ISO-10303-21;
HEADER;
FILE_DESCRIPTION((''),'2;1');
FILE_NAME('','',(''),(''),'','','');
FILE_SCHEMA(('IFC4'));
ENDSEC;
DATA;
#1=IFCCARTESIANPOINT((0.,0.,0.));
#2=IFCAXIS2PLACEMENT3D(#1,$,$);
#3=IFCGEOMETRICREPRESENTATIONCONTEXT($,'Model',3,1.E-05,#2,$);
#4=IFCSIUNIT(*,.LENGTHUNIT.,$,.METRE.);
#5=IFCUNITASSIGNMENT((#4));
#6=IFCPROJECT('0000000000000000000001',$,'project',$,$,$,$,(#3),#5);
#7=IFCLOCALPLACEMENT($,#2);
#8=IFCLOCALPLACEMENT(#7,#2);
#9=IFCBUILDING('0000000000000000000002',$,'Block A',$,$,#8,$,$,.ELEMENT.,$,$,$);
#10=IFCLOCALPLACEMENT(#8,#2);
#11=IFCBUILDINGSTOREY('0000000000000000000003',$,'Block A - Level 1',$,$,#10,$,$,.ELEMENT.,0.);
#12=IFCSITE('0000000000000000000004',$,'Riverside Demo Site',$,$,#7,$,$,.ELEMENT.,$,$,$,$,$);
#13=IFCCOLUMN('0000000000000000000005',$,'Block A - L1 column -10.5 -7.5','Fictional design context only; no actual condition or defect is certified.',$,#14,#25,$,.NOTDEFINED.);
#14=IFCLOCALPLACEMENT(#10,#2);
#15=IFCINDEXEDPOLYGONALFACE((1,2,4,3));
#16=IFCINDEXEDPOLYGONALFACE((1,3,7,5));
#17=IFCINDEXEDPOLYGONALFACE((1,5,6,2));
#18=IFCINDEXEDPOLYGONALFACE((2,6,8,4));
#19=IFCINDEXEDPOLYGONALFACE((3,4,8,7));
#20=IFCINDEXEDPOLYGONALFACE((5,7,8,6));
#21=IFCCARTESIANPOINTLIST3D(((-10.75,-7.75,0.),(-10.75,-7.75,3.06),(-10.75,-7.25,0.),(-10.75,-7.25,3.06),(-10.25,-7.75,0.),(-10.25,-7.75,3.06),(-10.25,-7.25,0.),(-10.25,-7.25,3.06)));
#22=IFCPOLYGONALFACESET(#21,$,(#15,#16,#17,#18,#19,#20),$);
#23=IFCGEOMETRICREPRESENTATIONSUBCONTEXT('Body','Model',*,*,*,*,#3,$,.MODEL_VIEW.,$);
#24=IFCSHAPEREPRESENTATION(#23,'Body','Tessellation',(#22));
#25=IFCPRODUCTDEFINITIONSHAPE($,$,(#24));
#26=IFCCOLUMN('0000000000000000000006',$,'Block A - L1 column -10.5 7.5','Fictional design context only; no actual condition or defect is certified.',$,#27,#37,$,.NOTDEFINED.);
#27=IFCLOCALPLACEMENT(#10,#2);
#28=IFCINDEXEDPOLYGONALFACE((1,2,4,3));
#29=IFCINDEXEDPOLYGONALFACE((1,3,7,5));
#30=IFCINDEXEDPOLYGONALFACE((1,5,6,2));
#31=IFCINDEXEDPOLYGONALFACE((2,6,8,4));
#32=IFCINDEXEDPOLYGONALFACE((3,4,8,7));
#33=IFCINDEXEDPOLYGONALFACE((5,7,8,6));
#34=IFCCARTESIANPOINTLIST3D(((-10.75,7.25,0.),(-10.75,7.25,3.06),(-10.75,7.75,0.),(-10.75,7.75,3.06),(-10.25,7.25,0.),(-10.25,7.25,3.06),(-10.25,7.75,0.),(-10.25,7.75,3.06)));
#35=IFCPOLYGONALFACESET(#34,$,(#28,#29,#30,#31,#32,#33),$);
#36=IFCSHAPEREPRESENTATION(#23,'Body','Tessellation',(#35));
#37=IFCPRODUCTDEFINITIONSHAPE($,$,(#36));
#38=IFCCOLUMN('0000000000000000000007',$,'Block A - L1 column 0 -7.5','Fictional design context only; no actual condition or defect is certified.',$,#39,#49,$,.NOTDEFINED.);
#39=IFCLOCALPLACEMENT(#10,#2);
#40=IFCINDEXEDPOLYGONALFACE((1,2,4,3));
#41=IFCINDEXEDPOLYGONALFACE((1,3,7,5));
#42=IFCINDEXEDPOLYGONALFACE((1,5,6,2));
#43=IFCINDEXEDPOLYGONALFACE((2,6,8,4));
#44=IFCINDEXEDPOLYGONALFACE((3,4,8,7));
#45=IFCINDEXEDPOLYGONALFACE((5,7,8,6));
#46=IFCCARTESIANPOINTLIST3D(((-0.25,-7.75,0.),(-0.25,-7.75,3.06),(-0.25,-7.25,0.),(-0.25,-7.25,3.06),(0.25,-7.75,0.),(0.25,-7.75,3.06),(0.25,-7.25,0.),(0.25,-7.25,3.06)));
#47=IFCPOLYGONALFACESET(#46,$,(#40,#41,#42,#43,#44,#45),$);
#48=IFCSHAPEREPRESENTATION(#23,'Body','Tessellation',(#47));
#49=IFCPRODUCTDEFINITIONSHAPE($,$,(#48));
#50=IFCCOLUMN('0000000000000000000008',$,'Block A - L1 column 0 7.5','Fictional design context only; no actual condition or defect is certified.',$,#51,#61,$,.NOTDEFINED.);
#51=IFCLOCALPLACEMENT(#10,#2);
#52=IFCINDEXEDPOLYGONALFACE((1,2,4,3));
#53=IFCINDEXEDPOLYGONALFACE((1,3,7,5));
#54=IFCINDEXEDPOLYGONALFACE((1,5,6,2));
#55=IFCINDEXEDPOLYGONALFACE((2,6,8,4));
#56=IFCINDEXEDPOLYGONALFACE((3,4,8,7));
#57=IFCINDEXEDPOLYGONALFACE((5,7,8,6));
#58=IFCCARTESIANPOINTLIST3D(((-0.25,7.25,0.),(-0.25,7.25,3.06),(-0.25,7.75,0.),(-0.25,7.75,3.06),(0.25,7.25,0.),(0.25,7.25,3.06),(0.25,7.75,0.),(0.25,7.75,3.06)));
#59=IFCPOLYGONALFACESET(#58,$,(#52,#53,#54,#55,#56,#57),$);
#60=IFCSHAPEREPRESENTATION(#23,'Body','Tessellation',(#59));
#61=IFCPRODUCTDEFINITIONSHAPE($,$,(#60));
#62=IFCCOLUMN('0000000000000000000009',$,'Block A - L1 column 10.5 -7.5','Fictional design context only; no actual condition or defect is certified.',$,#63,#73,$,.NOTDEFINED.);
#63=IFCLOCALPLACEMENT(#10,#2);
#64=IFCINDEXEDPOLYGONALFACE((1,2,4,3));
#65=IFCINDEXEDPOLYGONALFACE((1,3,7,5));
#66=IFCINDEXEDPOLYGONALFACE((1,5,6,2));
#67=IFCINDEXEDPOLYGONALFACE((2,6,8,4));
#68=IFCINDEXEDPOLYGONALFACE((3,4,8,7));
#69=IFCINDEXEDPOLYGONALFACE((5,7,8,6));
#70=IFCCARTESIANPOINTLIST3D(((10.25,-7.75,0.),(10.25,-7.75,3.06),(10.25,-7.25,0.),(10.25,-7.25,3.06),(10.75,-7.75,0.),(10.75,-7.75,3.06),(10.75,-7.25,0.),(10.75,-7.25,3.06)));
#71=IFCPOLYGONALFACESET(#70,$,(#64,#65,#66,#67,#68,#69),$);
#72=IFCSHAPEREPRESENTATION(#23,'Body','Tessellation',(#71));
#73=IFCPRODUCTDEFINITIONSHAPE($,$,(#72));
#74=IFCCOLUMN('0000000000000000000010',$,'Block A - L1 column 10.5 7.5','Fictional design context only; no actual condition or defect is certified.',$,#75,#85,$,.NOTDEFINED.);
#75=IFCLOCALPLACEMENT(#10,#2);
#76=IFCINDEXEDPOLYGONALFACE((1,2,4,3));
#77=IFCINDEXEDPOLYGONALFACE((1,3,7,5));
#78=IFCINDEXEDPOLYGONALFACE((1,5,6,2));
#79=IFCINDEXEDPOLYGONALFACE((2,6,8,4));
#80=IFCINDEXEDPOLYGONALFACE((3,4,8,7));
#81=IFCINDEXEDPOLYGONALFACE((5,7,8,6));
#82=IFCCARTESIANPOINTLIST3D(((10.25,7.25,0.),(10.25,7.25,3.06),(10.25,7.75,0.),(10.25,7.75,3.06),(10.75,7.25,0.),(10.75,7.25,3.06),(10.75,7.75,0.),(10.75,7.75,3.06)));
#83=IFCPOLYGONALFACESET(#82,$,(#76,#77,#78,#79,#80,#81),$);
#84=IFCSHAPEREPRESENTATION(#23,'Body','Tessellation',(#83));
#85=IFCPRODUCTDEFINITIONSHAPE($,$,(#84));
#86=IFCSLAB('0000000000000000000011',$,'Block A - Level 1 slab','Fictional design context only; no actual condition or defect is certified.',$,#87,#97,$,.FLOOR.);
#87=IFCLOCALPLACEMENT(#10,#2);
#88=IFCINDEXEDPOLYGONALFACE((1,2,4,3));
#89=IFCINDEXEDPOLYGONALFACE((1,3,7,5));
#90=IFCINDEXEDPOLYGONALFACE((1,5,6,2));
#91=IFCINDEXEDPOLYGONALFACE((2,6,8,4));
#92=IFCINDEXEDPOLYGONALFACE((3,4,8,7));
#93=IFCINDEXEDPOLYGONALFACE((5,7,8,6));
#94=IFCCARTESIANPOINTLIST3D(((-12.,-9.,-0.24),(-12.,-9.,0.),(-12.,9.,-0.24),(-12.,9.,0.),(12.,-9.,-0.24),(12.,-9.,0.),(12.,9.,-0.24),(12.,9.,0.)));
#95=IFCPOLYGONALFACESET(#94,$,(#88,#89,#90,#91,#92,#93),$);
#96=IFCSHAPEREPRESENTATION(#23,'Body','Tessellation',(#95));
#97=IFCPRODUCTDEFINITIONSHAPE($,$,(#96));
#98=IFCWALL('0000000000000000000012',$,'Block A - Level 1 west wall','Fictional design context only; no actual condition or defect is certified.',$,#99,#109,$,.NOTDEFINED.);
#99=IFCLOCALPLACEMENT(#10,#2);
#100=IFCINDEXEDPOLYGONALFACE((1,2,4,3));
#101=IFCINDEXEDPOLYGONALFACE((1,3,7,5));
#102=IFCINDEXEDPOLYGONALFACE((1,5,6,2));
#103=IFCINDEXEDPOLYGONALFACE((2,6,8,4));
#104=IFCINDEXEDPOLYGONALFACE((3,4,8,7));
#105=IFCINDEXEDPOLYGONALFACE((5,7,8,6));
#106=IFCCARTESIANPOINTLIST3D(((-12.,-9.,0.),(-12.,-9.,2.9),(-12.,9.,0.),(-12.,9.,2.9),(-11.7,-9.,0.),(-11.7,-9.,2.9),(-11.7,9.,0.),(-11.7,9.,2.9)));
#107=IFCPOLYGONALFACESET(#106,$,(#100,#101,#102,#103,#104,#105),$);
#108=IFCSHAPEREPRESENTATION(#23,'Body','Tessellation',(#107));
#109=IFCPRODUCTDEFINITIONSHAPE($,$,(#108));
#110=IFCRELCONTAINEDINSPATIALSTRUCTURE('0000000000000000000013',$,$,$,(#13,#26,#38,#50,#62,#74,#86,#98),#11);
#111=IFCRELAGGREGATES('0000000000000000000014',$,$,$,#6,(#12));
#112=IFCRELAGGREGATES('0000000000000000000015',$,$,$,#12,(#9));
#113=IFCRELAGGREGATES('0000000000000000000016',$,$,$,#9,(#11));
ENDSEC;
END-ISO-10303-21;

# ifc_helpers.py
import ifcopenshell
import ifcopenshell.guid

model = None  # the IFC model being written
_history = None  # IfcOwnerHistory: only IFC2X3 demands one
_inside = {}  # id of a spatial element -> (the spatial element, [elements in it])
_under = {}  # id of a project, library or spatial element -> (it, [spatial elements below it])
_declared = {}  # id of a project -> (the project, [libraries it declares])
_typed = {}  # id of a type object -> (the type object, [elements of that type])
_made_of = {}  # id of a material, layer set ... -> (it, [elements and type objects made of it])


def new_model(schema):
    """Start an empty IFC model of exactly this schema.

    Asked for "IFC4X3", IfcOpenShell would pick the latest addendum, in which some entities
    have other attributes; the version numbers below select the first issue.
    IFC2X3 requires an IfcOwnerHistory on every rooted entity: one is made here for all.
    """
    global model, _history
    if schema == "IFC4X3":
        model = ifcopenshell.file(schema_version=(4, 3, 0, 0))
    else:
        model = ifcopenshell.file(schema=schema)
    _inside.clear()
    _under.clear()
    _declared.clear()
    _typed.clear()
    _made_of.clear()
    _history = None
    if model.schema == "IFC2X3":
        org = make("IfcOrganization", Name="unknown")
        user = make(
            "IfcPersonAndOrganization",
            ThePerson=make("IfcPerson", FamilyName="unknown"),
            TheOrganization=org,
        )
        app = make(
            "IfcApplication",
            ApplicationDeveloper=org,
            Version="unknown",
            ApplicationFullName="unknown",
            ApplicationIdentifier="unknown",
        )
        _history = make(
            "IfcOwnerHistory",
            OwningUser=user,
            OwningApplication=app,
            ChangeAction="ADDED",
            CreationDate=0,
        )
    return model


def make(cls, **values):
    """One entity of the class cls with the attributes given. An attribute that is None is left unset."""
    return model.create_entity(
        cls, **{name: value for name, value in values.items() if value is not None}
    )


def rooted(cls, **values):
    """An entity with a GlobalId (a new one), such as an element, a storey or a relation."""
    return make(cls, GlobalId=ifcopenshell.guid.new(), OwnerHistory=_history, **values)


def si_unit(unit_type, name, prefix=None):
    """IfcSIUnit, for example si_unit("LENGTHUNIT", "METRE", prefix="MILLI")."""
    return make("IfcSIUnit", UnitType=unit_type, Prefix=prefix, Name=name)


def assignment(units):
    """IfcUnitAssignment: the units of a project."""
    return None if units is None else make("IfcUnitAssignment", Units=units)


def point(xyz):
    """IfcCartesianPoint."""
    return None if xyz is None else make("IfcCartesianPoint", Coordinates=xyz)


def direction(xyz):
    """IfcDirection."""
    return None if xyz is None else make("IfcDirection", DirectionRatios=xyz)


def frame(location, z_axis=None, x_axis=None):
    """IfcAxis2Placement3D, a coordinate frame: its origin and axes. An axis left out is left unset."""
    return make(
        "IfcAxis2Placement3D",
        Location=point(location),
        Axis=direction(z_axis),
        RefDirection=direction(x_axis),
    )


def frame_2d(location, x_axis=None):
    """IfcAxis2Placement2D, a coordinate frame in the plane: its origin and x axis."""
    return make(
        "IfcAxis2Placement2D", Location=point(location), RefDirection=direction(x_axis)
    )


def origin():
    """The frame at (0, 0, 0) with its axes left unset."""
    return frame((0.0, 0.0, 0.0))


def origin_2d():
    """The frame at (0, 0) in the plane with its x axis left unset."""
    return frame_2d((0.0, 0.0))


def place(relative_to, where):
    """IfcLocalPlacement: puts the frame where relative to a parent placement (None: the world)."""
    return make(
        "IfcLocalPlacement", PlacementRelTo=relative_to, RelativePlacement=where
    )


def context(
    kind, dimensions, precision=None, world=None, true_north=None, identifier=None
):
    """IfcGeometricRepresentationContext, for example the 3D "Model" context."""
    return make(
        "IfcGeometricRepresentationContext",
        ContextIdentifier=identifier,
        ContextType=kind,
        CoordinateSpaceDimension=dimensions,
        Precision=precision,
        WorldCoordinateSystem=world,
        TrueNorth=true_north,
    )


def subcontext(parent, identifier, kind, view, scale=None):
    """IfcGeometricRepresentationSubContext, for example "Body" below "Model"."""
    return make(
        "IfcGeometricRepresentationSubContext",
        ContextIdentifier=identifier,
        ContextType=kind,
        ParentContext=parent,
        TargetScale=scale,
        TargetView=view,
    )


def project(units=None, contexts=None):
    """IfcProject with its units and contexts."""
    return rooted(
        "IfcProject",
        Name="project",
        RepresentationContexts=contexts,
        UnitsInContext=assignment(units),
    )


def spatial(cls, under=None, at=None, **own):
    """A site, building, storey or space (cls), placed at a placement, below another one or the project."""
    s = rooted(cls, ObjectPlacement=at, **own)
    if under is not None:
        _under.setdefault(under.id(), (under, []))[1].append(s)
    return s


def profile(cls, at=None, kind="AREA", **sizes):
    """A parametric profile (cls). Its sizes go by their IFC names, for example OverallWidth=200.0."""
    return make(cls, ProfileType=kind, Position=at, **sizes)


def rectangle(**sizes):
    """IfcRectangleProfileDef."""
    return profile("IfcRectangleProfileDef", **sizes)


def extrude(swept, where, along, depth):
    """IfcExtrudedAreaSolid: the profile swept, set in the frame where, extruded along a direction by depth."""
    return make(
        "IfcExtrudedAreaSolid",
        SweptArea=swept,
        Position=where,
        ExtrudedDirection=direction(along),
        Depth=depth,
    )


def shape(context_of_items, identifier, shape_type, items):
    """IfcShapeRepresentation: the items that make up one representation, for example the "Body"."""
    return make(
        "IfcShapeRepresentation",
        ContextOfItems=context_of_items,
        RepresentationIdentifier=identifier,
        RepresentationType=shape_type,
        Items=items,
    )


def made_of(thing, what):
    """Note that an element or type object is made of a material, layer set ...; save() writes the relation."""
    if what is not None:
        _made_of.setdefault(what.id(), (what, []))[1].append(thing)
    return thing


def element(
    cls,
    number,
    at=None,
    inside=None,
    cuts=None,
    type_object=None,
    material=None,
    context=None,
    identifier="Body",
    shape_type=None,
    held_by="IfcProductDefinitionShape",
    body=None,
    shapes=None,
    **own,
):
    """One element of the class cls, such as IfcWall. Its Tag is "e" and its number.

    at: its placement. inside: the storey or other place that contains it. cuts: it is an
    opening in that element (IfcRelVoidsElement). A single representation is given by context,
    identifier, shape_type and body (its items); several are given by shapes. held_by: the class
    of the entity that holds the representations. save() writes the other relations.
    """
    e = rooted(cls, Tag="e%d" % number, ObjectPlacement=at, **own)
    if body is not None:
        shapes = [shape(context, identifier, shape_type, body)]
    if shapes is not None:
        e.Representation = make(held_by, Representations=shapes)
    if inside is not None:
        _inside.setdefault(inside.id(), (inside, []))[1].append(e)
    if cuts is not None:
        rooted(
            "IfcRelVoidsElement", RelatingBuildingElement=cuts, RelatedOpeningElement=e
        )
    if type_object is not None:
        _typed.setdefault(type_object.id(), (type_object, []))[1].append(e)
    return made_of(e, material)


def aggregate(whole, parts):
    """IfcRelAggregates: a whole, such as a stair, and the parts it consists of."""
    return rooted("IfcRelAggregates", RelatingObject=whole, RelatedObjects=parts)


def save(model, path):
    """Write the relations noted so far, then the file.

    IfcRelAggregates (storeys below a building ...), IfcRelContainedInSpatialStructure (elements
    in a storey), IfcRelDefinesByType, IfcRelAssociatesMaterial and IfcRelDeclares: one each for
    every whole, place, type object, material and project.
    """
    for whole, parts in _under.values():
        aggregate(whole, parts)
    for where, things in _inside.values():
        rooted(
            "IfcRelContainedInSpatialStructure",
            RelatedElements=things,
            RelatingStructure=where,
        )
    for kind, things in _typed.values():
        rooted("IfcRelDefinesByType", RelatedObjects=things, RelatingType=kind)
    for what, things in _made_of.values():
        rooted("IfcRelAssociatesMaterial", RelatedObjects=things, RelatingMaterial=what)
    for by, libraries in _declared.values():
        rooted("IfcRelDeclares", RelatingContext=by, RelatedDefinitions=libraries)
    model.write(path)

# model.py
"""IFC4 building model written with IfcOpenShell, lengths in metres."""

from ifc_helpers import new_model, si_unit, frame, origin, origin_2d, place, context, subcontext, project, spatial, rectangle, extrude, element, save


model = new_model("IFC4")

# Units and contexts
model_context = context("Model", 3, precision=1e-05, world=origin())
body_context = subcontext(model_context, "Body", "Model", "MODEL_VIEW")
ifc_project = project(units=[si_unit("LENGTHUNIT", "METRE")], contexts=[model_context])

# Site, building, storey
site_placement = place(None, origin())
site = spatial("IfcSite", under=ifc_project, at=site_placement, Name="Riverside Demo Site", CompositionType="ELEMENT")
building_placement = place(site_placement, origin())
building = spatial("IfcBuilding", under=site, at=building_placement, Name="Block A", CompositionType="ELEMENT")
storey_placement = place(building_placement, origin())
storey = spatial("IfcBuildingStorey", under=building, at=storey_placement, Name="Block A - Level 1", CompositionType="ELEMENT", Elevation=0.0)

# Columns
for number, where, name in (
    (1, (-10.5, -7.5, 0.0), "Block A - L1 column -10.5 -7.5"),
    (2, (-10.5, 7.5, 0.0), "Block A - L1 column -10.5 7.5"),
    (3, (0.0, -7.5, 0.0), "Block A - L1 column 0 -7.5"),
    (4, (0.0, 7.5, 0.0), "Block A - L1 column 0 7.5"),
    (5, (10.5, -7.5, 0.0), "Block A - L1 column 10.5 -7.5"),
    (6, (10.5, 7.5, 0.0), "Block A - L1 column 10.5 7.5"),
):
    element("IfcColumn", number, at=place(storey_placement, frame(where)), inside=storey, Name=name, Description="Fictional design context only; no actual condition or defect is certified.", PredefinedType="NOTDEFINED", context=body_context, shape_type="SweptSolid", body=[
        extrude(rectangle(XDim=0.5, YDim=0.5, at=origin_2d()), origin(), (0.0, 0.0, 1.0), 3.06),
    ])

# Slab
slab_placement = place(storey_placement, frame((0.0, 0.0, -0.24)))
element("IfcSlab", 7, at=slab_placement, inside=storey, Name="Block A - Level 1 slab", Description="Fictional design context only; no actual condition or defect is certified.", PredefinedType="FLOOR", context=body_context, shape_type="SweptSolid", body=[
    extrude(rectangle(XDim=24.0, YDim=18.0, at=origin_2d()), origin(), (0.0, 0.0, 1.0), 0.24),
])

# Wall
wall_placement = place(storey_placement, frame((-11.85, 0.0, 0.0)))
element("IfcWall", 8, at=wall_placement, inside=storey, Name="Block A - Level 1 west wall", Description="Fictional design context only; no actual condition or defect is certified.", PredefinedType="NOTDEFINED", context=body_context, shape_type="SweptSolid", body=[
    extrude(rectangle(XDim=0.3, YDim=18.0, at=origin_2d()), origin(), (0.0, 0.0, 1.0), 2.9),
])

save(model, "model.ifc")
